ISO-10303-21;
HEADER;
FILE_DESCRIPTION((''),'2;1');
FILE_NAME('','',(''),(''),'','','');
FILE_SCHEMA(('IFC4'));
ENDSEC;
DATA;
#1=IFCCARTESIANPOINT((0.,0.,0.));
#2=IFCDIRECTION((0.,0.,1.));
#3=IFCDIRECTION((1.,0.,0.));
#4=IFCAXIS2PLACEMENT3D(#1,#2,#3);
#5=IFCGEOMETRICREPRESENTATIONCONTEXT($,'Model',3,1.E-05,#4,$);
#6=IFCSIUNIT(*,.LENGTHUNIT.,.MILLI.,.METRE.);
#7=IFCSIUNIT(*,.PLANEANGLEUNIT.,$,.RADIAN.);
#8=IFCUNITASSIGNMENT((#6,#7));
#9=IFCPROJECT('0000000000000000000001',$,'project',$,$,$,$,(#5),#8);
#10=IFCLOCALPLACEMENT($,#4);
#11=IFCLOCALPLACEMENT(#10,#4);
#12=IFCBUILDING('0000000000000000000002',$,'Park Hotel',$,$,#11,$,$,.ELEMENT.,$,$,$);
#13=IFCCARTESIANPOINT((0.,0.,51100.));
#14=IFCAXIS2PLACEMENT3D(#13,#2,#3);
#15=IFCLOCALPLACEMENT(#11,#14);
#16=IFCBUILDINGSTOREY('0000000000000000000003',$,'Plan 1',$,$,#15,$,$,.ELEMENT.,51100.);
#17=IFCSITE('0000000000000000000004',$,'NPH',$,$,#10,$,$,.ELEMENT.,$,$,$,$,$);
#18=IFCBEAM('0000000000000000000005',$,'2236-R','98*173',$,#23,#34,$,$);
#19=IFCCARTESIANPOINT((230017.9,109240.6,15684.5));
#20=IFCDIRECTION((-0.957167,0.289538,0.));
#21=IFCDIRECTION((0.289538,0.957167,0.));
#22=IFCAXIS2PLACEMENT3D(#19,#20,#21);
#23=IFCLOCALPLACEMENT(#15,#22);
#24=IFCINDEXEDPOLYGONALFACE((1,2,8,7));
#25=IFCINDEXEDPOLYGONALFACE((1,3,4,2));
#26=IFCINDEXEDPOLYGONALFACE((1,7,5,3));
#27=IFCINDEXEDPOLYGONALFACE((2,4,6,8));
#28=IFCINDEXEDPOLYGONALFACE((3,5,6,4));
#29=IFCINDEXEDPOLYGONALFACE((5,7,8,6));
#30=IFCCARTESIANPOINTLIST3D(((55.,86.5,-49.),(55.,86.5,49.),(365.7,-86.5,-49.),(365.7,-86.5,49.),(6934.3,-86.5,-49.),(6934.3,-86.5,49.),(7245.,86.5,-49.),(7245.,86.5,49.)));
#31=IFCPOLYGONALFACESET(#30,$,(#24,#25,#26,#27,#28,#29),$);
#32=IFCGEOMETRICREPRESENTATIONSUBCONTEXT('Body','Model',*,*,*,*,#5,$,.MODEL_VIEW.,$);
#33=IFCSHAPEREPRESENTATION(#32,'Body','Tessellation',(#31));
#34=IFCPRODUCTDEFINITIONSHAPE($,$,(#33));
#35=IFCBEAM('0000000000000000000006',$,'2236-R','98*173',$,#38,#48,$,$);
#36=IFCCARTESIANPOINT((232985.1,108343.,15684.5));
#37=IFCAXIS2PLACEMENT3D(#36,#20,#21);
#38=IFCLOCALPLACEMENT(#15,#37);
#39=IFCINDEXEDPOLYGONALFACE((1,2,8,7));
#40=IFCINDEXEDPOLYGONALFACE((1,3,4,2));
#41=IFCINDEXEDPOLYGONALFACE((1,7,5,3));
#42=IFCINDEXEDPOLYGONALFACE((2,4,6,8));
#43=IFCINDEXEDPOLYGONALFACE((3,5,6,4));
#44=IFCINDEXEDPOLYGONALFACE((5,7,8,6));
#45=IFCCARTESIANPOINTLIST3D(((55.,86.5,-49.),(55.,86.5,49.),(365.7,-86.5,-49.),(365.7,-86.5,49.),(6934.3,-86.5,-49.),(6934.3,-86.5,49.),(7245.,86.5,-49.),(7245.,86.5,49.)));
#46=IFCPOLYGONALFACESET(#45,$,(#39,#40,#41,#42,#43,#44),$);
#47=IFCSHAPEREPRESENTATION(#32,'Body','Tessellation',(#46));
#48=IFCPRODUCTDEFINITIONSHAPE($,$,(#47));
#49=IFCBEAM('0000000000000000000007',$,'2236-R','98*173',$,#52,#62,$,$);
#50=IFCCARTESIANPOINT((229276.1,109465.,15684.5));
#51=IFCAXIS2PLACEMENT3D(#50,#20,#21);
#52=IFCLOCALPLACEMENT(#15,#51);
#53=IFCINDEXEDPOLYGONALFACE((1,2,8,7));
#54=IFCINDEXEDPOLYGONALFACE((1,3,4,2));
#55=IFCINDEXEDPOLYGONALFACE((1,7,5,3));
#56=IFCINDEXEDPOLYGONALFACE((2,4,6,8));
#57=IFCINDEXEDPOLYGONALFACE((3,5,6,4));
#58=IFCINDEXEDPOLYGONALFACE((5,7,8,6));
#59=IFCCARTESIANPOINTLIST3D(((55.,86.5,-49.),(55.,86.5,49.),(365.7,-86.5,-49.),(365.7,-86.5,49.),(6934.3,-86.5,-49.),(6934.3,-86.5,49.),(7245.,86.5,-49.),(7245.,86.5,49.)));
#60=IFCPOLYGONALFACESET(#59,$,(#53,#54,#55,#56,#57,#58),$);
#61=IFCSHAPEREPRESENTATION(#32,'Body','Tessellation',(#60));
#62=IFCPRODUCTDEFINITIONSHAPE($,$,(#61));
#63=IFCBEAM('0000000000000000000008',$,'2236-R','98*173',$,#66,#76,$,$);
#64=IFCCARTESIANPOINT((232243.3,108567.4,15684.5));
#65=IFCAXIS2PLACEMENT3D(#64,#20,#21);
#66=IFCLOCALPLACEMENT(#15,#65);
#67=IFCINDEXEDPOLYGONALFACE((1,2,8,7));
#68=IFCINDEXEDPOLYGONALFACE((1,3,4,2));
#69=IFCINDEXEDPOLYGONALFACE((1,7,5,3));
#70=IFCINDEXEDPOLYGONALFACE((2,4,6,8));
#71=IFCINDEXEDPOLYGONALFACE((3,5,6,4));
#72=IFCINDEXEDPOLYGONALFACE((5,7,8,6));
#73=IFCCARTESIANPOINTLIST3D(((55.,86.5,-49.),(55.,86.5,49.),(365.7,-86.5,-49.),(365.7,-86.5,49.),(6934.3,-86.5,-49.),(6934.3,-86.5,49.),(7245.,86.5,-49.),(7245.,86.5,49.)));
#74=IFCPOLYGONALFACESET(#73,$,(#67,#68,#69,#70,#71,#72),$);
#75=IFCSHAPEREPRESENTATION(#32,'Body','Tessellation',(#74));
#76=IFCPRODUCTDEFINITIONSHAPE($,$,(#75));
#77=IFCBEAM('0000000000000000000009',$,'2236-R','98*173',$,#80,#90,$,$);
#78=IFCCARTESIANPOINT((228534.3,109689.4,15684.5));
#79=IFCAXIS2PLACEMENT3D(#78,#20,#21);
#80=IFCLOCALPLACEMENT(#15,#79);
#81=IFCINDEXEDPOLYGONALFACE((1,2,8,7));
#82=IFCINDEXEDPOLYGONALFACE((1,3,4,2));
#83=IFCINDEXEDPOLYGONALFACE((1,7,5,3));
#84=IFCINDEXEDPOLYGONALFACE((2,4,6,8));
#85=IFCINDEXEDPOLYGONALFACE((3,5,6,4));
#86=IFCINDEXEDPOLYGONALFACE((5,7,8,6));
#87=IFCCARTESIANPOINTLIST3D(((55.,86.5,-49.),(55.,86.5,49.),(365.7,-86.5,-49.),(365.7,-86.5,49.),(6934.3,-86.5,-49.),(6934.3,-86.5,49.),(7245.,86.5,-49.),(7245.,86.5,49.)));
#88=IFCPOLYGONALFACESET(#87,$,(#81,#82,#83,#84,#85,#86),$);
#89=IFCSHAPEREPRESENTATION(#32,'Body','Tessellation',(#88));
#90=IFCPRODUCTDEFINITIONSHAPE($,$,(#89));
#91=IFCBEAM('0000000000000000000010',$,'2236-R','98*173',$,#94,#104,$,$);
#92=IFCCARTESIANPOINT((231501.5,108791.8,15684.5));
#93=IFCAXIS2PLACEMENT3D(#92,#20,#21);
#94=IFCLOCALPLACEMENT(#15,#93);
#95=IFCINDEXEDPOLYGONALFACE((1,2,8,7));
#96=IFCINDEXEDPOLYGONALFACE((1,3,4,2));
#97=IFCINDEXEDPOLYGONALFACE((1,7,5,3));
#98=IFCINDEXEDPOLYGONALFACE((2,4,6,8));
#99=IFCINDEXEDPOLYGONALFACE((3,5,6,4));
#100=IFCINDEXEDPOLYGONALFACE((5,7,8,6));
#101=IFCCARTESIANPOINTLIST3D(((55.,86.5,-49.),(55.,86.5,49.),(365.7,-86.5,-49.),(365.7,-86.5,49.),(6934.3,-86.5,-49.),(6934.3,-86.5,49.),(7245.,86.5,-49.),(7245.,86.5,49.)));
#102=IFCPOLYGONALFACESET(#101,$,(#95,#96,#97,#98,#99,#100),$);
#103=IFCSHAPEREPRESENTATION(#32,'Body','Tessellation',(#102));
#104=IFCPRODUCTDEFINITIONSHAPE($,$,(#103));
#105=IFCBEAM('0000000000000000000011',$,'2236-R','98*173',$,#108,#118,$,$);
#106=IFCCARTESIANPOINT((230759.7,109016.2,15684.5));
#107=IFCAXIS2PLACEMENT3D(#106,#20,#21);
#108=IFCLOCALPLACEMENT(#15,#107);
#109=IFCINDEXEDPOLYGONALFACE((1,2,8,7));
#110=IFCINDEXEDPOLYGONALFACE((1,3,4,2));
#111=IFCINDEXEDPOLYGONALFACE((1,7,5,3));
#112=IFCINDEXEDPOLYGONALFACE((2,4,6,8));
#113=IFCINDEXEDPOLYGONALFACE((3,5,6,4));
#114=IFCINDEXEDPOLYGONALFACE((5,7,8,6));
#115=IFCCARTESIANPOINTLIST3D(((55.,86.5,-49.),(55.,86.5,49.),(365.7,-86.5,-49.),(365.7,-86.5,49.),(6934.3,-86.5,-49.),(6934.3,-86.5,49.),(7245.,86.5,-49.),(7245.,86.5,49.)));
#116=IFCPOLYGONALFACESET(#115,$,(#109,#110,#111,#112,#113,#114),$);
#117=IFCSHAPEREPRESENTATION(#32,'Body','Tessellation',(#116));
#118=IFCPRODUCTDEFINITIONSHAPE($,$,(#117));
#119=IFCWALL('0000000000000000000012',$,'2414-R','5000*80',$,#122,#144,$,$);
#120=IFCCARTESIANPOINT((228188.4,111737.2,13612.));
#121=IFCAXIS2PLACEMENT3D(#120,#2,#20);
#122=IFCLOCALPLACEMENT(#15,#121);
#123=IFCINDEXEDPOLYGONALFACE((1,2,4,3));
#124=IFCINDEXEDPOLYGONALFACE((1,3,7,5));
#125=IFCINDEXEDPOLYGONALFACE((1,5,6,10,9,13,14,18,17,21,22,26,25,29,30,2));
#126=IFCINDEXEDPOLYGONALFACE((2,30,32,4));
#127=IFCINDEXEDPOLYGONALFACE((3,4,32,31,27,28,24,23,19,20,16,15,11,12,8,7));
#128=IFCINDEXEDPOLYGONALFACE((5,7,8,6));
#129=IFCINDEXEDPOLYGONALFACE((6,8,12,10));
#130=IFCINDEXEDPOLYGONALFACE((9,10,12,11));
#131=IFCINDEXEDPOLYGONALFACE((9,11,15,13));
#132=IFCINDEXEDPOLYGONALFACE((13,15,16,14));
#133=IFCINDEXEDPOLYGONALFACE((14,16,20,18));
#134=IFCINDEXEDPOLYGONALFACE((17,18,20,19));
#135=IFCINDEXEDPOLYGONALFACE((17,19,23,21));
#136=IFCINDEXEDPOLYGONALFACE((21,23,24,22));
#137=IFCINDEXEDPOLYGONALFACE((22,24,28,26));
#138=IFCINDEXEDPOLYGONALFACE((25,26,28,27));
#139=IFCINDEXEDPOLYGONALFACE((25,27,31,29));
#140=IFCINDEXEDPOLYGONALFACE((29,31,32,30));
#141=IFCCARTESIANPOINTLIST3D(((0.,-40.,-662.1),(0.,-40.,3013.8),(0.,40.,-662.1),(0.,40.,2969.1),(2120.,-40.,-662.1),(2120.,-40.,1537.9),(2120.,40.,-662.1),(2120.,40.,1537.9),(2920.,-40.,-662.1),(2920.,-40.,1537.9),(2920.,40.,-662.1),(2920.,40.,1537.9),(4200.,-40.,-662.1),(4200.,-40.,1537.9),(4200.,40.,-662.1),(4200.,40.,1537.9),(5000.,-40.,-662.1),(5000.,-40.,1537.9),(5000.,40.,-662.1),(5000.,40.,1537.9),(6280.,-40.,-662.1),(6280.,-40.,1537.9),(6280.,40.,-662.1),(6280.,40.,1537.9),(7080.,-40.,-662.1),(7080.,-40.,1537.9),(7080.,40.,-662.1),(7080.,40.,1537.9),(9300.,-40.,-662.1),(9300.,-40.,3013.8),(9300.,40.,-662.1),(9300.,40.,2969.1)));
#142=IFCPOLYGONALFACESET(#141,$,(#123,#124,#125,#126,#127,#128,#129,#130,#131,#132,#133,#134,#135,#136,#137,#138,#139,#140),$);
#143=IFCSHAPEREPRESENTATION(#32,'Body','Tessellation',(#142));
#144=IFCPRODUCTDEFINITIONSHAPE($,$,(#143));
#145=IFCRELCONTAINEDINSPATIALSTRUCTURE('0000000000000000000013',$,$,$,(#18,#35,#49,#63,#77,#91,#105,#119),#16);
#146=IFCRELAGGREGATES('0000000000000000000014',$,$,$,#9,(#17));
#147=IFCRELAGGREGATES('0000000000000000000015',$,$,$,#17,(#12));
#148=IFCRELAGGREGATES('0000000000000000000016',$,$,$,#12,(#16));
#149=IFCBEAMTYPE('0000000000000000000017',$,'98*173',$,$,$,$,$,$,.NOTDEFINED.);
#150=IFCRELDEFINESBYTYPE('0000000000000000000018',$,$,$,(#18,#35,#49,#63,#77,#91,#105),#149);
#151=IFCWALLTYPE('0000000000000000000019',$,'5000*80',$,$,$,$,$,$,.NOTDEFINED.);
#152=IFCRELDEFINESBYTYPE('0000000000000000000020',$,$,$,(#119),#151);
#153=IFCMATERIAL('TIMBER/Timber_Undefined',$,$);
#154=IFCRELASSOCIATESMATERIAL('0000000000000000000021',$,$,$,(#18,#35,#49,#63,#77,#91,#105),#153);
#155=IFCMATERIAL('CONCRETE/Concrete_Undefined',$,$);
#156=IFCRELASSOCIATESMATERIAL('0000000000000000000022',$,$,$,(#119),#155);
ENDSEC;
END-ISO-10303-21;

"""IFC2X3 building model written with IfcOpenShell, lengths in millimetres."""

from ifc_helpers import new_model, si_unit, frame, frame_2d, origin_with_axes, origin_2d_with_axis, place, context, subcontext, project, spatial, rectangle, extrude, boolean, clip, halfspace, material, type_object, element, save


model = new_model("IFC2X3")

# Units and contexts
model_context = context("Model", 3, precision=1e-05, world=origin_with_axes())
body_context = subcontext(model_context, "Body", "Model", "MODEL_VIEW")
ifc_project = project(units=[si_unit("LENGTHUNIT", "METRE", prefix="MILLI"), si_unit("PLANEANGLEUNIT", "RADIAN")], contexts=[model_context])

# Site, building, storey
site_placement = place(None, origin_with_axes())
site = spatial("IfcSite", under=ifc_project, at=site_placement, Name="NPH", CompositionType="ELEMENT")
building_placement = place(site_placement, origin_with_axes())
building = spatial("IfcBuilding", under=site, at=building_placement, Name="Park Hotel", CompositionType="ELEMENT")
storey_placement = place(building_placement, frame((0.0, 0.0, 51100.0), z_axis=(0.0, 0.0, 1.0), x_axis=(1.0, 0.0, 0.0)))
storey = spatial("IfcBuildingStorey", under=building, at=storey_placement, Name="Plan 1", CompositionType="ELEMENT", Elevation=51100.0)

# Shared definitions
ifc_material_1 = material(Name="TIMBER/Timber_Undefined")

# Beams
beam_type_1 = type_object("IfcBeamType", Name="98*173", PredefinedType="NOTDEFINED")
beam_1_placement = place(storey_placement, frame((230017.9, 109240.6, 15684.5), z_axis=(-0.957167, 0.289538, 0.0), x_axis=(0.289538, 0.957167, 0.0)))
element("IfcBeam", 1, at=beam_1_placement, inside=storey, type_object=beam_type_1, material=ifc_material_1, Name="2236-R", Description="98*173", context=body_context, shape_type="Clipping", body=[
    clip(clip(extrude(rectangle(XDim=173.0, YDim=98.0, at=origin_2d_with_axis()), frame((7270.0, 0.0, 0.0), z_axis=(-1.0, 0.0, 0.0), x_axis=(0.0, -1.0, 0.0)), (0.0, 0.0, 1.0), 7270.0), halfspace(frame((55.0, 86.5, -649.0), z_axis=(-0.486528, -0.873665, 0.0), x_axis=(0.0, 0.0, 1.0)), False)), halfspace(frame((7245.0, 86.5, 49.0), z_axis=(0.486529, -0.873664, 0.0), x_axis=(0.0, 0.0, -1.0)), False)),
])
beam_2_placement = place(storey_placement, frame((232985.1, 108343.0, 15684.5), z_axis=(-0.957167, 0.289538, 0.0), x_axis=(0.289538, 0.957167, 0.0)))
element("IfcBeam", 2, at=beam_2_placement, inside=storey, type_object=beam_type_1, material=ifc_material_1, Name="2236-R", Description="98*173", context=body_context, shape_type="Clipping", body=[
    clip(clip(extrude(rectangle(XDim=173.0, YDim=98.0, at=origin_2d_with_axis()), frame((7270.0, 0.0, 0.0), z_axis=(-1.0, 0.0, 0.0), x_axis=(0.0, -1.0, 0.0)), (0.0, 0.0, 1.0), 7270.0), halfspace(frame((55.0, 86.5, -49.0), z_axis=(-0.486528, -0.873665, 0.0), x_axis=(0.0, 0.0, 1.0)), False)), halfspace(frame((7245.0, 86.5, 49.0), z_axis=(0.486529, -0.873664, 0.0), x_axis=(0.0, 0.0, -1.0)), False)),
])
beam_3_placement = place(storey_placement, frame((229276.1, 109465.0, 15684.5), z_axis=(-0.957167, 0.289538, 0.0), x_axis=(0.289538, 0.957167, 0.0)))
element("IfcBeam", 3, at=beam_3_placement, inside=storey, type_object=beam_type_1, material=ifc_material_1, Name="2236-R", Description="98*173", context=body_context, shape_type="Clipping", body=[
    clip(clip(extrude(rectangle(XDim=173.0, YDim=98.0, at=origin_2d_with_axis()), frame((7270.0, 0.0, 0.0), z_axis=(-1.0, 0.0, 0.0), x_axis=(0.0, -1.0, 0.0)), (0.0, 0.0, 1.0), 7270.0), halfspace(frame((55.0, 86.5, -649.0), z_axis=(-0.486528, -0.873665, 0.0), x_axis=(0.0, 0.0, 1.0)), False)), halfspace(frame((7245.0, 86.5, 49.0), z_axis=(0.486529, -0.873664, 0.0), x_axis=(0.0, 0.0, -1.0)), False)),
])
beam_4_placement = place(storey_placement, frame((232243.3, 108567.4, 15684.5), z_axis=(-0.957167, 0.289538, 0.0), x_axis=(0.289538, 0.957167, 0.0)))
element("IfcBeam", 4, at=beam_4_placement, inside=storey, type_object=beam_type_1, material=ifc_material_1, Name="2236-R", Description="98*173", context=body_context, shape_type="Clipping", body=[
    clip(clip(extrude(rectangle(XDim=173.0, YDim=98.0, at=origin_2d_with_axis()), frame((7270.0, 0.0, 0.0), z_axis=(-1.0, 0.0, 0.0), x_axis=(0.0, -1.0, 0.0)), (0.0, 0.0, 1.0), 7270.0), halfspace(frame((55.0, 86.5, -49.0), z_axis=(-0.486528, -0.873665, 0.0), x_axis=(0.0, 0.0, 1.0)), False)), halfspace(frame((7245.0, 86.5, 49.0), z_axis=(0.486529, -0.873664, 0.0), x_axis=(0.0, 0.0, -1.0)), False)),
])
beam_5_placement = place(storey_placement, frame((228534.3, 109689.4, 15684.5), z_axis=(-0.957167, 0.289538, 0.0), x_axis=(0.289538, 0.957167, 0.0)))
element("IfcBeam", 5, at=beam_5_placement, inside=storey, type_object=beam_type_1, material=ifc_material_1, Name="2236-R", Description="98*173", context=body_context, shape_type="Clipping", body=[
    clip(clip(extrude(rectangle(XDim=173.0, YDim=98.0, at=origin_2d_with_axis()), frame((7270.0, 0.0, 0.0), z_axis=(-1.0, 0.0, 0.0), x_axis=(0.0, -1.0, 0.0)), (0.0, 0.0, 1.0), 7270.0), halfspace(frame((55.0, 86.5, -649.0), z_axis=(-0.486528, -0.873665, 0.0), x_axis=(0.0, 0.0, 1.0)), False)), halfspace(frame((7245.0, 86.5, 49.0), z_axis=(0.486529, -0.873664, 0.0), x_axis=(0.0, 0.0, -1.0)), False)),
])
for number, where, z_axis, x_axis, name in (
    (6, (231501.5, 108791.8, 15684.5), (-0.957167, 0.289538, 0.0), (0.289538, 0.957167, 0.0), "2236-R"),
    (7, (230759.7, 109016.2, 15684.5), (-0.957167, 0.289538, 0.0), (0.289538, 0.957167, 0.0), "2236-R"),
):
    element("IfcBeam", number, at=place(storey_placement, frame(where, z_axis=z_axis, x_axis=x_axis)), inside=storey, type_object=beam_type_1, material=ifc_material_1, Name=name, Description="98*173", context=body_context, shape_type="Clipping", body=[
        clip(clip(extrude(rectangle(XDim=173.0, YDim=98.0, at=origin_2d_with_axis()), frame((7270.0, 0.0, 0.0), z_axis=(-1.0, 0.0, 0.0), x_axis=(0.0, -1.0, 0.0)), (0.0, 0.0, 1.0), 7270.0), halfspace(frame((55.0, 86.5, -49.0), z_axis=(-0.486528, -0.873665, 0.0), x_axis=(0.0, 0.0, 1.0)), False)), halfspace(frame((7245.0, 86.5, 49.0), z_axis=(0.486529, -0.873664, 0.0), x_axis=(0.0, 0.0, -1.0)), False)),
    ])

# Wall
ifc_material_2 = material(Name="CONCRETE/Concrete_Undefined")
wall_type_1 = type_object("IfcWallType", Name="5000*80", PredefinedType="NOTDEFINED")
wall_1_placement = place(storey_placement, frame((228188.4, 111737.2, 13612.0), z_axis=(0.0, 0.0, 1.0), x_axis=(-0.957167, 0.289538, 0.0)))
element("IfcWall", 8, at=wall_1_placement, inside=storey, type_object=wall_type_1, material=ifc_material_2, Name="2414-R", Description="5000*80", context=body_context, shape_type="CSG", body=[
    boolean("DIFFERENCE", boolean("DIFFERENCE", boolean("DIFFERENCE", boolean("DIFFERENCE", extrude(rectangle(XDim=9300.0, YDim=80.0, at=frame_2d((0.0, 4650.0), x_axis=(0.0, -1.0))), frame((0.0, 0.0, -662.1), z_axis=(0.0, 0.0, 1.0), x_axis=(0.0, -1.0, 0.0)), (0.0, 0.0, 1.0), 5000.0), extrude(rectangle(XDim=800.0, YDim=150.0, at=frame_2d((0.0, 400.0), x_axis=(0.0, -1.0))), frame((5000.0, -34.8, -662.1), z_axis=(0.0, 0.0, 1.0), x_axis=(0.000005, 1.0, 0.0)), (0.0, 0.0, 1.0), 2200.0)), extrude(rectangle(XDim=800.0, YDim=150.0, at=frame_2d((0.0, 400.0), x_axis=(0.0, -1.0))), frame((2920.0, -34.8, -662.1), z_axis=(0.0, 0.0, 1.0), x_axis=(0.000005, 1.0, 0.0)), (0.0, 0.0, 1.0), 2200.0)), extrude(rectangle(XDim=800.0, YDim=150.0, at=frame_2d((0.0, 400.0), x_axis=(0.0, -1.0))), frame((7080.0, -34.8, -662.1), z_axis=(0.0, 0.0, 1.0), x_axis=(0.000005, 1.0, 0.0)), (0.0, 0.0, 1.0), 2200.0)), halfspace(frame((9300.0, 40.0, 2969.1), z_axis=(0.0, 0.487877, 0.872912), x_axis=(0.0, -0.872912, 0.487877)), False)),
])

save(model, "model.ifc")
